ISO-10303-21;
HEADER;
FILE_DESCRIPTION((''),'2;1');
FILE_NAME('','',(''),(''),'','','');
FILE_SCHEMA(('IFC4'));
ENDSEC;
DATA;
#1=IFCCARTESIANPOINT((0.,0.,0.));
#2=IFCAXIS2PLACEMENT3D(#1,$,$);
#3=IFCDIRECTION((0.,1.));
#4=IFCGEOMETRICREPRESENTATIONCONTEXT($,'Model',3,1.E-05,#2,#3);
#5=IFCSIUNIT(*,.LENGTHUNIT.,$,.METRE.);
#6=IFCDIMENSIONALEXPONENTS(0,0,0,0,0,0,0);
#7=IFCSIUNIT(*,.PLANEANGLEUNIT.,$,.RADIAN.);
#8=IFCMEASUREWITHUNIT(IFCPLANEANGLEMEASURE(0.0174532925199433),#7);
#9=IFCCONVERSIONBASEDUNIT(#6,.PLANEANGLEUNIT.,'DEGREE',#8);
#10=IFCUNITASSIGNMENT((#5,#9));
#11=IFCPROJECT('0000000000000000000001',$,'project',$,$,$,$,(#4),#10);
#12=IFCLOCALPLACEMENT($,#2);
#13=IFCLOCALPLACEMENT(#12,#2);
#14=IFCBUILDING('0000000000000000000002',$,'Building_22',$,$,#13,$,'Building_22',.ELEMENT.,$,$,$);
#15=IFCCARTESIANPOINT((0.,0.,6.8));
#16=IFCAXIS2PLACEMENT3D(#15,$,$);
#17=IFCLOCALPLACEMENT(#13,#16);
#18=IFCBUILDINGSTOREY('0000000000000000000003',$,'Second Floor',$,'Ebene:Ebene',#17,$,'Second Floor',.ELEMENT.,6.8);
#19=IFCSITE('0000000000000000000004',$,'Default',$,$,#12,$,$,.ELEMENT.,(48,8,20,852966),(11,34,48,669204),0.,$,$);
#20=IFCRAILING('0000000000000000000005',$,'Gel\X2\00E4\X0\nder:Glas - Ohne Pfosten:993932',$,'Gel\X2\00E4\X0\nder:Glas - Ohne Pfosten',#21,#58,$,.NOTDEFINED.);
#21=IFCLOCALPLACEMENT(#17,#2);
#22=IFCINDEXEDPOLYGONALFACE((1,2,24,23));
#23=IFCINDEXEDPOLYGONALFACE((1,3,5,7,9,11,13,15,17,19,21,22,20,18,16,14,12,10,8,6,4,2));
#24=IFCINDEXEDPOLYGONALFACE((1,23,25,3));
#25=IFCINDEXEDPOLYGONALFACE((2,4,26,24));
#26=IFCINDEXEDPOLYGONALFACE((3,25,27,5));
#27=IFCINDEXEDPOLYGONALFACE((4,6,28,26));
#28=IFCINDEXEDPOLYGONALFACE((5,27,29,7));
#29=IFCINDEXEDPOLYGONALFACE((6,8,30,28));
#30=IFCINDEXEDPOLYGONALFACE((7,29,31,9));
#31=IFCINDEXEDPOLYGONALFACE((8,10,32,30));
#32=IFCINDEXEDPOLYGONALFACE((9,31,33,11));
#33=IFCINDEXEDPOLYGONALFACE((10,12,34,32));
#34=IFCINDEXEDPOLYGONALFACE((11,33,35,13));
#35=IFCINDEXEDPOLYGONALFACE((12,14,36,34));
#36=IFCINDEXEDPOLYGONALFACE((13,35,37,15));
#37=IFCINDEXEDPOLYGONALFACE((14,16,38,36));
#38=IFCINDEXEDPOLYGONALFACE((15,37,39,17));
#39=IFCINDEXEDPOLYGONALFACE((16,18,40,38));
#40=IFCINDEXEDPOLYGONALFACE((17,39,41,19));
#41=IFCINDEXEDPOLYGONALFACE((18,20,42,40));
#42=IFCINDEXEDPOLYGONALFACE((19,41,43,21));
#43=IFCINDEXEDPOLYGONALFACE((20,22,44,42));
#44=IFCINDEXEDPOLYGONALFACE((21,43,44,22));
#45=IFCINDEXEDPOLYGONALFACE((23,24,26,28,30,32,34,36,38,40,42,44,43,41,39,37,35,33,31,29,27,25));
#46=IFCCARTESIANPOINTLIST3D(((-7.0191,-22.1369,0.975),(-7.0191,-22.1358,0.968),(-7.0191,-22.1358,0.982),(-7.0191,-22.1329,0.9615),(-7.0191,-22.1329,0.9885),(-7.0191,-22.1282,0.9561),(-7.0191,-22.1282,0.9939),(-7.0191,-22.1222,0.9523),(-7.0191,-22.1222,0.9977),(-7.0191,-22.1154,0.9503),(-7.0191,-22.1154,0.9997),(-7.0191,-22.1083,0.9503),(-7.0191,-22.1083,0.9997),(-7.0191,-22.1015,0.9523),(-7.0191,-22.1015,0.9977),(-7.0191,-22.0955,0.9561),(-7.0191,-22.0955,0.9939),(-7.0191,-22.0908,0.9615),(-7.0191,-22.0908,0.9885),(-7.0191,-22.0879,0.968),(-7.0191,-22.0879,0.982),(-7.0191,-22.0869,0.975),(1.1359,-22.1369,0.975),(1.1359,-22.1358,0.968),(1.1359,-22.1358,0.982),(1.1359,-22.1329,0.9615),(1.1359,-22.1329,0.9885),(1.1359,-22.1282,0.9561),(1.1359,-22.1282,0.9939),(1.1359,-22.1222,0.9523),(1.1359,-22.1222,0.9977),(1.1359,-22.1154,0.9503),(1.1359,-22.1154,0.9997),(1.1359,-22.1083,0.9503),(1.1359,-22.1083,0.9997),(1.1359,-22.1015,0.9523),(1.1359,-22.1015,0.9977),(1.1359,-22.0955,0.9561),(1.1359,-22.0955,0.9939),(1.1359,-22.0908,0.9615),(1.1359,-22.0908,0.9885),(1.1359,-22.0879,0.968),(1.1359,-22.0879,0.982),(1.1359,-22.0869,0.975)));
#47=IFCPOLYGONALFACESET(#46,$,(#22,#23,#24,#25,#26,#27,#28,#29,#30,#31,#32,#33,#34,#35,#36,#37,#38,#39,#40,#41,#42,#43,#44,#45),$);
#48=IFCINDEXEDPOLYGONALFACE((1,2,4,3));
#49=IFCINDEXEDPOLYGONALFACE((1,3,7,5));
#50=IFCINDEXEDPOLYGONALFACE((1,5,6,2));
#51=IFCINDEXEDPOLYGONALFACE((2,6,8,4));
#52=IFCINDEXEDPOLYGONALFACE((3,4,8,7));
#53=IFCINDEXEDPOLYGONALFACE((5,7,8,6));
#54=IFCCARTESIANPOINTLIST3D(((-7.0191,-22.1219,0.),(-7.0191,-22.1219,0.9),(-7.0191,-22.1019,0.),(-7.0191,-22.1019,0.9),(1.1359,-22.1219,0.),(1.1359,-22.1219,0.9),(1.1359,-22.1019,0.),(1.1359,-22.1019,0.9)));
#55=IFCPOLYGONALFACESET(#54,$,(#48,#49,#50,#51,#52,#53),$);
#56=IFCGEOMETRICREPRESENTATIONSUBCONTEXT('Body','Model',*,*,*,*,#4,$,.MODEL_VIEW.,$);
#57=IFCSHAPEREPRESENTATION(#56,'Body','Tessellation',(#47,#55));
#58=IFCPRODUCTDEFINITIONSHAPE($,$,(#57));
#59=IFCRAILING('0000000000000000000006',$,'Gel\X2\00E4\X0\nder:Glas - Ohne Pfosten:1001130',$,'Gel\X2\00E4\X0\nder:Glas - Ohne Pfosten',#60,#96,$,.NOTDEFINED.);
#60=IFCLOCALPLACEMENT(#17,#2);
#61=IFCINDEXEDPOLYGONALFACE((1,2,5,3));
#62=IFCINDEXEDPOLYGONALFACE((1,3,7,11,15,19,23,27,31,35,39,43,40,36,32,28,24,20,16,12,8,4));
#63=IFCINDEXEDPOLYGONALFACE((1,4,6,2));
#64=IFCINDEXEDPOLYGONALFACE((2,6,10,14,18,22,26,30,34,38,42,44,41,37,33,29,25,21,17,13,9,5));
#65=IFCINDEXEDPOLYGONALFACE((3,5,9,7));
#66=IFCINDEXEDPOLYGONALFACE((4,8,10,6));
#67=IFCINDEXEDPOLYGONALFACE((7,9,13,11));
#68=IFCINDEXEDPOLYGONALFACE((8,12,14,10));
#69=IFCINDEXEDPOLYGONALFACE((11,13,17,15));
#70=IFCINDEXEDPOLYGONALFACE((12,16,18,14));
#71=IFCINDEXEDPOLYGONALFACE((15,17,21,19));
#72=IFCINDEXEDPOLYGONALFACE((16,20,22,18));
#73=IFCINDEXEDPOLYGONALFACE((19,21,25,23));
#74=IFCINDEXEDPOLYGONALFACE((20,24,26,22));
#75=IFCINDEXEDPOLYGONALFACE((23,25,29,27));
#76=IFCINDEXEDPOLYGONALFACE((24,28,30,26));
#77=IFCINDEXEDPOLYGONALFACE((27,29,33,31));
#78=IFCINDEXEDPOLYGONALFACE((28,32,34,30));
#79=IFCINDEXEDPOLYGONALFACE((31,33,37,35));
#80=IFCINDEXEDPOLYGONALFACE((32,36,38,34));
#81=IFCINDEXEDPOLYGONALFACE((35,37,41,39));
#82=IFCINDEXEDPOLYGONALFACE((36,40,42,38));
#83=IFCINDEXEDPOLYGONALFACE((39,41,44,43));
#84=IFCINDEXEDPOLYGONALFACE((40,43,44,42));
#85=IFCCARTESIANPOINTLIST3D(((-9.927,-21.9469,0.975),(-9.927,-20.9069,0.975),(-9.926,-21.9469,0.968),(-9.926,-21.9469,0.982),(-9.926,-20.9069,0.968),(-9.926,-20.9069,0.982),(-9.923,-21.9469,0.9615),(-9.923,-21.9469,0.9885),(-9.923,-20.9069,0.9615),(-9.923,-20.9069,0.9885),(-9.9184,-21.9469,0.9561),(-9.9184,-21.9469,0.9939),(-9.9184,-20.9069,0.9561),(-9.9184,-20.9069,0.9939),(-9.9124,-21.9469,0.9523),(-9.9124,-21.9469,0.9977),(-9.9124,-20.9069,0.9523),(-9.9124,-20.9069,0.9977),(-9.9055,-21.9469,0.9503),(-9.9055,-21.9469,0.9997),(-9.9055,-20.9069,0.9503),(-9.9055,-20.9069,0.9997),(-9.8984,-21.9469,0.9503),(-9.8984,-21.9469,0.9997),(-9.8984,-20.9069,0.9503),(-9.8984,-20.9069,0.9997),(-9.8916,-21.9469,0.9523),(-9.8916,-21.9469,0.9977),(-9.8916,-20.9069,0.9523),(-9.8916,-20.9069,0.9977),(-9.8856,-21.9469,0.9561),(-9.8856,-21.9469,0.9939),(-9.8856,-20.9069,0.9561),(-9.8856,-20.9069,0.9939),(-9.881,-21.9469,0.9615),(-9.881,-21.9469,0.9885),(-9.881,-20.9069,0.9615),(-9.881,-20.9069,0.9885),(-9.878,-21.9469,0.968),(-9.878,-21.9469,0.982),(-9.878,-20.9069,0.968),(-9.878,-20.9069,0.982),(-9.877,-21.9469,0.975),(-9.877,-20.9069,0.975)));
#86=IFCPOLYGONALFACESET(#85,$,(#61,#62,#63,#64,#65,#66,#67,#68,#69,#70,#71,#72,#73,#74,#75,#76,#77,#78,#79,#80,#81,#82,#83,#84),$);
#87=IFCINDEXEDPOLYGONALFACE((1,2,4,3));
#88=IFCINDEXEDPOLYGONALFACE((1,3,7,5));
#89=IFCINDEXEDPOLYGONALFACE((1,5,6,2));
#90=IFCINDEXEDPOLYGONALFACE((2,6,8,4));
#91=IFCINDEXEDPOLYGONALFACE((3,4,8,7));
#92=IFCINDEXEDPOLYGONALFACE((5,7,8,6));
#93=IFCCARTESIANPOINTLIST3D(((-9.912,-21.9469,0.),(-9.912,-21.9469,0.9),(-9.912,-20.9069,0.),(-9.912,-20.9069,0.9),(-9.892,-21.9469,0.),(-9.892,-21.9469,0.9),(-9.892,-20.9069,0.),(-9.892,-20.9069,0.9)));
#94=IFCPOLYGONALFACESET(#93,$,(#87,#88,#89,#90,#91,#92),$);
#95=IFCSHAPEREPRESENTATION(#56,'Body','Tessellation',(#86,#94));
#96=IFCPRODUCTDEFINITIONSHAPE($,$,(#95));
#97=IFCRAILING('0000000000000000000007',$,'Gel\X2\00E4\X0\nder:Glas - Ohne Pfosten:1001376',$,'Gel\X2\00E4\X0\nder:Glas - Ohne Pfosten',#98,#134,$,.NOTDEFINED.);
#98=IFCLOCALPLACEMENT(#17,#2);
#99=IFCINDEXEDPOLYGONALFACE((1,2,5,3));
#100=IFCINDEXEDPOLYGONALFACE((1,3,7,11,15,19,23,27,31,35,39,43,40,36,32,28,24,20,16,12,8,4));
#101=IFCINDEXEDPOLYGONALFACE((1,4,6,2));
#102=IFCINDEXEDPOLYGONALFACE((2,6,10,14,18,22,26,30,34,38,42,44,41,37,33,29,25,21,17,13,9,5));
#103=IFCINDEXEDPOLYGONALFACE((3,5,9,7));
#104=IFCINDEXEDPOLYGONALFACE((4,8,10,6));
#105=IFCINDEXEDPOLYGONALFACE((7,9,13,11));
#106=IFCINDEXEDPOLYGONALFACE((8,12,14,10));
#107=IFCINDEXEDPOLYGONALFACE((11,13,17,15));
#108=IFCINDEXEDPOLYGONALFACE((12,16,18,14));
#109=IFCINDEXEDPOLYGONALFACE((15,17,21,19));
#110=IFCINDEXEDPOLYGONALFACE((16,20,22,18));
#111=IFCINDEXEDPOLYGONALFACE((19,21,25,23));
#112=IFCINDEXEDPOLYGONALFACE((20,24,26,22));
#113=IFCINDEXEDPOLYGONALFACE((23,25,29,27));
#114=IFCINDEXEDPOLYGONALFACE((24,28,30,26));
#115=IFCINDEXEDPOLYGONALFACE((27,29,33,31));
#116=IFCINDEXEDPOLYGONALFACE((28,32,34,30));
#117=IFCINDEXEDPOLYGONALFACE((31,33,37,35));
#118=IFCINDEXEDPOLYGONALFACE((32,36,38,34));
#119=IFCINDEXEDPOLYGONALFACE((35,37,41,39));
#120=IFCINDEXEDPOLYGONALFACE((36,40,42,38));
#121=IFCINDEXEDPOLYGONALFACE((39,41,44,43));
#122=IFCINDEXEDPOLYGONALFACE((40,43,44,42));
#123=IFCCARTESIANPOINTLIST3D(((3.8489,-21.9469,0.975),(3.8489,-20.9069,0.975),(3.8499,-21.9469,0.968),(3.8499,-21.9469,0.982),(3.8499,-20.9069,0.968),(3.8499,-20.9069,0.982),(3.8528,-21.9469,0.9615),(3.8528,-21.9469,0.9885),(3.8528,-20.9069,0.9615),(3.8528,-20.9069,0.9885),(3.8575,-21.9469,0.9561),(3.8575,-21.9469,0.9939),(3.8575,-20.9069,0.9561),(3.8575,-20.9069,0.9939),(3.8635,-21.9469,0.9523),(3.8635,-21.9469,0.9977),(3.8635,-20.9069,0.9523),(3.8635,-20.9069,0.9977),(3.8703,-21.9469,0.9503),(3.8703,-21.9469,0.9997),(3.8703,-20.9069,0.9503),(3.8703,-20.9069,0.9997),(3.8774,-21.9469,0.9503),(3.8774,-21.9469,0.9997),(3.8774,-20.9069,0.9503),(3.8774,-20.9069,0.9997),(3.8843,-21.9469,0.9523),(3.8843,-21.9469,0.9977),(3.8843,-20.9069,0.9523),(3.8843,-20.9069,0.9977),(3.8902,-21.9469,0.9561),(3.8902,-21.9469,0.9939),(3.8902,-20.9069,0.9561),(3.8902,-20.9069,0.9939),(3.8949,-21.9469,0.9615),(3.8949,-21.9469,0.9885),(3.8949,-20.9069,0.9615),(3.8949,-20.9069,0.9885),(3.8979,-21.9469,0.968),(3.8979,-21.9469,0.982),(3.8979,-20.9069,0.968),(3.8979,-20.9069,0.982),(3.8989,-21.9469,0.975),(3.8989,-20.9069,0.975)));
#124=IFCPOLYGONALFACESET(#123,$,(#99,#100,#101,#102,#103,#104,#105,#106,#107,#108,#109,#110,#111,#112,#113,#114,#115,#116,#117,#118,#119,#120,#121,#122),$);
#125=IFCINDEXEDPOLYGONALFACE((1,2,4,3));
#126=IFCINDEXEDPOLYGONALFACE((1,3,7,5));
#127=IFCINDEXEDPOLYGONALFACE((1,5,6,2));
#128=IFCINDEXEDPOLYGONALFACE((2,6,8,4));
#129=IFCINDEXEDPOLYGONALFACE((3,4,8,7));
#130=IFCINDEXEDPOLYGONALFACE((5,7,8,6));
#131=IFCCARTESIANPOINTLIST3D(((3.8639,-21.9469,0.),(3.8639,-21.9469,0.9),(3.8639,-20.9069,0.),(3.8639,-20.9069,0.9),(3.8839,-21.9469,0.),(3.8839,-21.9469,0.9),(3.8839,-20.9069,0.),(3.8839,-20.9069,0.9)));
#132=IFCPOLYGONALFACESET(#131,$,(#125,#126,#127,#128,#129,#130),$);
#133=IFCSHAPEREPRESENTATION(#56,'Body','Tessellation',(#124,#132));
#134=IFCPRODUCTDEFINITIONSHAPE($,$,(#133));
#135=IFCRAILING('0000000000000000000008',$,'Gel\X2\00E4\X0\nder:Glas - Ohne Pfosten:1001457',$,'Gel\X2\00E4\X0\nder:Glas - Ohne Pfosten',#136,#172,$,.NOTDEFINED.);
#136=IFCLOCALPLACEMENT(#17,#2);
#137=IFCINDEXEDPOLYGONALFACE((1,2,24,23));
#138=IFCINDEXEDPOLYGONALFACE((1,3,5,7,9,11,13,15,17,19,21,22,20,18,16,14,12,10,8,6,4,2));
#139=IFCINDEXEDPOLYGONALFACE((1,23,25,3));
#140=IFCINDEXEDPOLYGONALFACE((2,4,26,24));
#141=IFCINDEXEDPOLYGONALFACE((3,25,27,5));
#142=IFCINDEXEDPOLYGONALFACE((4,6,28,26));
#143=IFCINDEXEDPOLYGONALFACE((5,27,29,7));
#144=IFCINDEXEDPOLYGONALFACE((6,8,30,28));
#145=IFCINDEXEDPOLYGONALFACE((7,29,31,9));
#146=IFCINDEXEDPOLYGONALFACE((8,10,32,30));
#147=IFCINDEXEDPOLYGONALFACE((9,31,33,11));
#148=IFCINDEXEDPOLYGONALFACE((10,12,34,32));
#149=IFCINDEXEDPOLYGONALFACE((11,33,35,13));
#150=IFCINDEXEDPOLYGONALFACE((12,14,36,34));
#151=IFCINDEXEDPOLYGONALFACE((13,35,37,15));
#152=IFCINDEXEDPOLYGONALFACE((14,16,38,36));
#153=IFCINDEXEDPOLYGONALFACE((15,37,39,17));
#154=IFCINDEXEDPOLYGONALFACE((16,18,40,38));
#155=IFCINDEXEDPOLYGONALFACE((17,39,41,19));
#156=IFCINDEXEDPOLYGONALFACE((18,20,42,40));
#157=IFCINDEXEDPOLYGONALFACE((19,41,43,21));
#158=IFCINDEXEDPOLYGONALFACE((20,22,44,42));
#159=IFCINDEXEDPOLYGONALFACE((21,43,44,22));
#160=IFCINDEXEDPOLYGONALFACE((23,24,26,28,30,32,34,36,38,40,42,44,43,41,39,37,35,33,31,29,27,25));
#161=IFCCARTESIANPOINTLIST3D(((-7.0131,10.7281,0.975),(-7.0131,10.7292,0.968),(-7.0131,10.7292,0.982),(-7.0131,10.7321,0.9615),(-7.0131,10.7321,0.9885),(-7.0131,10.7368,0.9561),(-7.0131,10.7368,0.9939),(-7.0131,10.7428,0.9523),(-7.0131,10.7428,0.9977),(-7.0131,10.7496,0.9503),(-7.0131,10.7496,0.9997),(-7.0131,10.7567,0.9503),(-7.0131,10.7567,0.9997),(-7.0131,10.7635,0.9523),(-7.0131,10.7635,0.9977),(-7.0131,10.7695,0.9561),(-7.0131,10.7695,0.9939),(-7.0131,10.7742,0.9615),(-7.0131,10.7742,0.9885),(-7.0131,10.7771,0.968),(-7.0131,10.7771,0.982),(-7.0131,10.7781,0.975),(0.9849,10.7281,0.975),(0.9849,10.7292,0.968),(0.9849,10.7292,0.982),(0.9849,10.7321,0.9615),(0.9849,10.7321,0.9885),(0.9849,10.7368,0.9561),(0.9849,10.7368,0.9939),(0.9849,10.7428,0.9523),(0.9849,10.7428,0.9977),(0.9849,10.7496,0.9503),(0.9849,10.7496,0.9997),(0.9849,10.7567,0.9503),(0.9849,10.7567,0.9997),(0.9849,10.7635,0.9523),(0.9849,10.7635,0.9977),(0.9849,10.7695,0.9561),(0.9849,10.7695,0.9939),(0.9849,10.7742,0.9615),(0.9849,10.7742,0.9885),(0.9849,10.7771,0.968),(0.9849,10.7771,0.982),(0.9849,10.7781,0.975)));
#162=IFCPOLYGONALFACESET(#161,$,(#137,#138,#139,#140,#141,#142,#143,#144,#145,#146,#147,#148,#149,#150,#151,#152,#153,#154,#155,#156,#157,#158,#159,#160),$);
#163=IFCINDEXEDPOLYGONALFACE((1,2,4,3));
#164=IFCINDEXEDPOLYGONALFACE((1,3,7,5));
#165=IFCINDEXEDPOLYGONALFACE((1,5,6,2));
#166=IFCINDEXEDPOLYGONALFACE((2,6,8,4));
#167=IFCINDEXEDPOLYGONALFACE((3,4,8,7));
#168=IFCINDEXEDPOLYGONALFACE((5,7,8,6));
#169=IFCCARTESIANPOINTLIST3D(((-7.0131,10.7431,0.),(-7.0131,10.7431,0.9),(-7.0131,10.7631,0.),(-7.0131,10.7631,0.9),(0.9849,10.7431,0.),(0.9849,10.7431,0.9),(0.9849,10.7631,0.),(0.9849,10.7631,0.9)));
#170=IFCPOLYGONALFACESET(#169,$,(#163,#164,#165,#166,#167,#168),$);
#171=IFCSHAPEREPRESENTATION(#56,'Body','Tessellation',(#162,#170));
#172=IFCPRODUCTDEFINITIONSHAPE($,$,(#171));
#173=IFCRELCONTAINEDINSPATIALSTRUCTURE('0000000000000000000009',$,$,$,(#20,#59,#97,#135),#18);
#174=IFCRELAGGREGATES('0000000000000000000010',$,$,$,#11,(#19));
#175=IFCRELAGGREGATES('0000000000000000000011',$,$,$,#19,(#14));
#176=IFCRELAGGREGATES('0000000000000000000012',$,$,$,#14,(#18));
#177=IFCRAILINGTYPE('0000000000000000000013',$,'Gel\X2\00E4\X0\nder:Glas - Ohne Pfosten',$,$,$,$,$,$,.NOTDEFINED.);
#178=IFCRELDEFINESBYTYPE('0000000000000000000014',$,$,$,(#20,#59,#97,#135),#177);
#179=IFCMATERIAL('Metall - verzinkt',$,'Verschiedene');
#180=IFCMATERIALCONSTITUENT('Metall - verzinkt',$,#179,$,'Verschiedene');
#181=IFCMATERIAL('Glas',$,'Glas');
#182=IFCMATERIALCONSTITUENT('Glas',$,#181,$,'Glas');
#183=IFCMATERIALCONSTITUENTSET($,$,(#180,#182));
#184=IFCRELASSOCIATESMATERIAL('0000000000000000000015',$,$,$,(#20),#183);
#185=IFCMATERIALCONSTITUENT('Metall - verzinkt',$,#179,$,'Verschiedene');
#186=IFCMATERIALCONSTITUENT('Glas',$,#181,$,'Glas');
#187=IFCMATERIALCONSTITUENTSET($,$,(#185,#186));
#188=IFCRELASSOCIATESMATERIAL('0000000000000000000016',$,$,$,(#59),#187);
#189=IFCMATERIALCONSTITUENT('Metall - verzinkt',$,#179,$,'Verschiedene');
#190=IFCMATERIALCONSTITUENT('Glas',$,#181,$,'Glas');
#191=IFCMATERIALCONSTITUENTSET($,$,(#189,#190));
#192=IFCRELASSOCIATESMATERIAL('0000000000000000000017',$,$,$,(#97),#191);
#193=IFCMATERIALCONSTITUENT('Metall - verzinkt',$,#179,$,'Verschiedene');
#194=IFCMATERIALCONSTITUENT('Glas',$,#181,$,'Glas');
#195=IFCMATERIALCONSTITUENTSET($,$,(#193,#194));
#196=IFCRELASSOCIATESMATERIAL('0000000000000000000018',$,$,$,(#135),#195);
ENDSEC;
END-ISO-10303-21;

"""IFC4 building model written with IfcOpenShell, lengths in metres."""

from ifc_helpers import new_model, entity, si_unit, converted_unit, direction, frame, origin, place, context, subcontext, project, spatial, arc, indexed_curve, outline, extrude, material, constituent, constituent_set, type_object, element, save


model = new_model("IFC4")

# Units and contexts
model_context = context("Model", 3, precision=1e-05, world=origin(), true_north=direction((0.0, 1.0)))
body_context = subcontext(model_context, "Body", "Model", "MODEL_VIEW")
ifc_project = project(units=[si_unit("LENGTHUNIT", "METRE"), converted_unit("PLANEANGLEUNIT", "DEGREE", entity("IfcPlaneAngleMeasure", 0.0174532925199433), si_unit("PLANEANGLEUNIT", "RADIAN"), dimensions=[0, 0, 0, 0, 0, 0, 0])], contexts=[model_context])

# Site, building, storey
site_placement = place(None, origin())
site = spatial("IfcSite", under=ifc_project, at=site_placement, Name="Default", CompositionType="ELEMENT", RefLatitude=(48, 8, 20, 852966), RefLongitude=(11, 34, 48, 669204), RefElevation=0.0)
building_placement = place(site_placement, origin())
building = spatial("IfcBuilding", under=site, at=building_placement, Name="Building_22", LongName="Building_22", CompositionType="ELEMENT")
storey_placement = place(building_placement, frame((0.0, 0.0, 6.8)))
storey = spatial("IfcBuildingStorey", under=building, at=storey_placement, Name="Second Floor", ObjectType="Ebene:Ebene", LongName="Second Floor", CompositionType="ELEMENT", Elevation=6.8)

# Shared definitions
ifc_material_1 = material(Name="Metall - verzinkt", Category="Verschiedene")

# Shared definitions
ifc_material_2 = material(Name="Glas", Category="Glas")

# Railings
ifc_constituent_1 = constituent(ifc_material_1, Name="Metall - verzinkt", Category="Verschiedene")
ifc_constituent_2 = constituent(ifc_material_2, Name="Glas", Category="Glas")
ifc_constituent_set_1 = constituent_set(constituents=[ifc_constituent_1, ifc_constituent_2])
railing_type = type_object("IfcRailingType", Name="Geländer:Glas - Ohne Pfosten", PredefinedType="NOTDEFINED")
railing_1_placement = place(storey_placement, origin())
element("IfcRailing", 1, at=railing_1_placement, inside=storey, type_object=railing_type, material=ifc_constituent_set_1, Name="Geländer:Glas - Ohne Pfosten:993932", ObjectType="Geländer:Glas - Ohne Pfosten", PredefinedType="NOTDEFINED", context=body_context, shape_type="SweptSolid", body=[
    extrude(outline(indexed_curve([(-0.025, 0.0), (0.0, -0.025), (0.025, 0.0), (0.0, 0.025)], segments=[arc(1, 2, 3), arc(3, 4, 1)], self_intersect=False)), frame((-7.0191, -22.1119, 0.975), z_axis=(1.0, 0.0, 0.0), x_axis=(0.0, -1.0, 0.0)), (0.0, 0.0, 1.0), 8.155),
    extrude(outline(indexed_curve([(-4.0775, -0.01), (4.0775, -0.01), (4.0775, 0.01), (-4.0775, 0.01), (-4.0775, -0.01)], self_intersect=False)), frame((-2.9416, -22.1119, 0.0)), (0.0, 0.0, 1.0), 0.9),
])
ifc_constituent_3 = constituent(ifc_material_1, Name="Metall - verzinkt", Category="Verschiedene")
ifc_constituent_4 = constituent(ifc_material_2, Name="Glas", Category="Glas")
ifc_constituent_set_2 = constituent_set(constituents=[ifc_constituent_3, ifc_constituent_4])
railing_2_placement = place(storey_placement, origin())
element("IfcRailing", 2, at=railing_2_placement, inside=storey, type_object=railing_type, material=ifc_constituent_set_2, Name="Geländer:Glas - Ohne Pfosten:1001130", ObjectType="Geländer:Glas - Ohne Pfosten", PredefinedType="NOTDEFINED", context=body_context, shape_type="SweptSolid", body=[
    extrude(outline(indexed_curve([(-0.025, 0.0), (0.0, -0.025), (0.025, 0.0), (0.0, 0.025)], segments=[arc(1, 2, 3), arc(3, 4, 1)], self_intersect=False)), frame((-9.902, -21.9469, 0.975), z_axis=(0.0, 1.0, 0.0), x_axis=(-1.0, 0.0, 0.0)), (0.0, 0.0, 1.0), 1.04),
    extrude(outline(indexed_curve([(-0.52, -0.01), (0.52, -0.01), (0.52, 0.01), (-0.52, 0.01), (-0.52, -0.01)], self_intersect=False)), frame((-9.902, -21.4269, 0.0), z_axis=(0.0, 0.0, 1.0), x_axis=(0.0, -1.0, 0.0)), (0.0, 0.0, 1.0), 0.9),
])
ifc_constituent_5 = constituent(ifc_material_1, Name="Metall - verzinkt", Category="Verschiedene")
ifc_constituent_6 = constituent(ifc_material_2, Name="Glas", Category="Glas")
ifc_constituent_set_3 = constituent_set(constituents=[ifc_constituent_5, ifc_constituent_6])
railing_3_placement = place(storey_placement, origin())
element("IfcRailing", 3, at=railing_3_placement, inside=storey, type_object=railing_type, material=ifc_constituent_set_3, Name="Geländer:Glas - Ohne Pfosten:1001376", ObjectType="Geländer:Glas - Ohne Pfosten", PredefinedType="NOTDEFINED", context=body_context, shape_type="SweptSolid", body=[
    extrude(outline(indexed_curve([(-0.025, 0.0), (0.0, -0.025), (0.025, 0.0), (0.0, 0.025)], segments=[arc(1, 2, 3), arc(3, 4, 1)], self_intersect=False)), frame((3.8739, -21.9469, 0.975), z_axis=(0.0, 1.0, 0.0), x_axis=(1.0, 0.0, 0.0)), (0.0, 0.0, 1.0), 1.04),
    extrude(outline(indexed_curve([(-0.52, -0.01), (0.52, -0.01), (0.52, 0.01), (-0.52, 0.01), (-0.52, -0.01)], self_intersect=False)), frame((3.8739, -21.4269, 0.0), z_axis=(0.0, 0.0, 1.0), x_axis=(0.0, -1.0, 0.0)), (0.0, 0.0, 1.0), 0.9),
])
ifc_constituent_7 = constituent(ifc_material_1, Name="Metall - verzinkt", Category="Verschiedene")
ifc_constituent_8 = constituent(ifc_material_2, Name="Glas", Category="Glas")
ifc_constituent_set_4 = constituent_set(constituents=[ifc_constituent_7, ifc_constituent_8])
railing_4_placement = place(storey_placement, origin())
element("IfcRailing", 4, at=railing_4_placement, inside=storey, type_object=railing_type, material=ifc_constituent_set_4, Name="Geländer:Glas - Ohne Pfosten:1001457", ObjectType="Geländer:Glas - Ohne Pfosten", PredefinedType="NOTDEFINED", context=body_context, shape_type="SweptSolid", body=[
    extrude(outline(indexed_curve([(-0.025, 0.0), (0.0, -0.025), (0.025, 0.0), (0.0, 0.025)], segments=[arc(1, 2, 3), arc(3, 4, 1)], self_intersect=False)), frame((-7.0131, 10.7531, 0.975), z_axis=(1.0, 0.0, 0.0), x_axis=(0.0, -1.0, 0.0)), (0.0, 0.0, 1.0), 7.998),
    extrude(outline(indexed_curve([(-3.999, -0.01), (3.999, -0.01), (3.999, 0.01), (-3.999, 0.01), (-3.999, -0.01)], self_intersect=False)), frame((-3.0141, 10.7531, 0.0)), (0.0, 0.0, 1.0), 0.9),
])

save(model, "model.ifc")
